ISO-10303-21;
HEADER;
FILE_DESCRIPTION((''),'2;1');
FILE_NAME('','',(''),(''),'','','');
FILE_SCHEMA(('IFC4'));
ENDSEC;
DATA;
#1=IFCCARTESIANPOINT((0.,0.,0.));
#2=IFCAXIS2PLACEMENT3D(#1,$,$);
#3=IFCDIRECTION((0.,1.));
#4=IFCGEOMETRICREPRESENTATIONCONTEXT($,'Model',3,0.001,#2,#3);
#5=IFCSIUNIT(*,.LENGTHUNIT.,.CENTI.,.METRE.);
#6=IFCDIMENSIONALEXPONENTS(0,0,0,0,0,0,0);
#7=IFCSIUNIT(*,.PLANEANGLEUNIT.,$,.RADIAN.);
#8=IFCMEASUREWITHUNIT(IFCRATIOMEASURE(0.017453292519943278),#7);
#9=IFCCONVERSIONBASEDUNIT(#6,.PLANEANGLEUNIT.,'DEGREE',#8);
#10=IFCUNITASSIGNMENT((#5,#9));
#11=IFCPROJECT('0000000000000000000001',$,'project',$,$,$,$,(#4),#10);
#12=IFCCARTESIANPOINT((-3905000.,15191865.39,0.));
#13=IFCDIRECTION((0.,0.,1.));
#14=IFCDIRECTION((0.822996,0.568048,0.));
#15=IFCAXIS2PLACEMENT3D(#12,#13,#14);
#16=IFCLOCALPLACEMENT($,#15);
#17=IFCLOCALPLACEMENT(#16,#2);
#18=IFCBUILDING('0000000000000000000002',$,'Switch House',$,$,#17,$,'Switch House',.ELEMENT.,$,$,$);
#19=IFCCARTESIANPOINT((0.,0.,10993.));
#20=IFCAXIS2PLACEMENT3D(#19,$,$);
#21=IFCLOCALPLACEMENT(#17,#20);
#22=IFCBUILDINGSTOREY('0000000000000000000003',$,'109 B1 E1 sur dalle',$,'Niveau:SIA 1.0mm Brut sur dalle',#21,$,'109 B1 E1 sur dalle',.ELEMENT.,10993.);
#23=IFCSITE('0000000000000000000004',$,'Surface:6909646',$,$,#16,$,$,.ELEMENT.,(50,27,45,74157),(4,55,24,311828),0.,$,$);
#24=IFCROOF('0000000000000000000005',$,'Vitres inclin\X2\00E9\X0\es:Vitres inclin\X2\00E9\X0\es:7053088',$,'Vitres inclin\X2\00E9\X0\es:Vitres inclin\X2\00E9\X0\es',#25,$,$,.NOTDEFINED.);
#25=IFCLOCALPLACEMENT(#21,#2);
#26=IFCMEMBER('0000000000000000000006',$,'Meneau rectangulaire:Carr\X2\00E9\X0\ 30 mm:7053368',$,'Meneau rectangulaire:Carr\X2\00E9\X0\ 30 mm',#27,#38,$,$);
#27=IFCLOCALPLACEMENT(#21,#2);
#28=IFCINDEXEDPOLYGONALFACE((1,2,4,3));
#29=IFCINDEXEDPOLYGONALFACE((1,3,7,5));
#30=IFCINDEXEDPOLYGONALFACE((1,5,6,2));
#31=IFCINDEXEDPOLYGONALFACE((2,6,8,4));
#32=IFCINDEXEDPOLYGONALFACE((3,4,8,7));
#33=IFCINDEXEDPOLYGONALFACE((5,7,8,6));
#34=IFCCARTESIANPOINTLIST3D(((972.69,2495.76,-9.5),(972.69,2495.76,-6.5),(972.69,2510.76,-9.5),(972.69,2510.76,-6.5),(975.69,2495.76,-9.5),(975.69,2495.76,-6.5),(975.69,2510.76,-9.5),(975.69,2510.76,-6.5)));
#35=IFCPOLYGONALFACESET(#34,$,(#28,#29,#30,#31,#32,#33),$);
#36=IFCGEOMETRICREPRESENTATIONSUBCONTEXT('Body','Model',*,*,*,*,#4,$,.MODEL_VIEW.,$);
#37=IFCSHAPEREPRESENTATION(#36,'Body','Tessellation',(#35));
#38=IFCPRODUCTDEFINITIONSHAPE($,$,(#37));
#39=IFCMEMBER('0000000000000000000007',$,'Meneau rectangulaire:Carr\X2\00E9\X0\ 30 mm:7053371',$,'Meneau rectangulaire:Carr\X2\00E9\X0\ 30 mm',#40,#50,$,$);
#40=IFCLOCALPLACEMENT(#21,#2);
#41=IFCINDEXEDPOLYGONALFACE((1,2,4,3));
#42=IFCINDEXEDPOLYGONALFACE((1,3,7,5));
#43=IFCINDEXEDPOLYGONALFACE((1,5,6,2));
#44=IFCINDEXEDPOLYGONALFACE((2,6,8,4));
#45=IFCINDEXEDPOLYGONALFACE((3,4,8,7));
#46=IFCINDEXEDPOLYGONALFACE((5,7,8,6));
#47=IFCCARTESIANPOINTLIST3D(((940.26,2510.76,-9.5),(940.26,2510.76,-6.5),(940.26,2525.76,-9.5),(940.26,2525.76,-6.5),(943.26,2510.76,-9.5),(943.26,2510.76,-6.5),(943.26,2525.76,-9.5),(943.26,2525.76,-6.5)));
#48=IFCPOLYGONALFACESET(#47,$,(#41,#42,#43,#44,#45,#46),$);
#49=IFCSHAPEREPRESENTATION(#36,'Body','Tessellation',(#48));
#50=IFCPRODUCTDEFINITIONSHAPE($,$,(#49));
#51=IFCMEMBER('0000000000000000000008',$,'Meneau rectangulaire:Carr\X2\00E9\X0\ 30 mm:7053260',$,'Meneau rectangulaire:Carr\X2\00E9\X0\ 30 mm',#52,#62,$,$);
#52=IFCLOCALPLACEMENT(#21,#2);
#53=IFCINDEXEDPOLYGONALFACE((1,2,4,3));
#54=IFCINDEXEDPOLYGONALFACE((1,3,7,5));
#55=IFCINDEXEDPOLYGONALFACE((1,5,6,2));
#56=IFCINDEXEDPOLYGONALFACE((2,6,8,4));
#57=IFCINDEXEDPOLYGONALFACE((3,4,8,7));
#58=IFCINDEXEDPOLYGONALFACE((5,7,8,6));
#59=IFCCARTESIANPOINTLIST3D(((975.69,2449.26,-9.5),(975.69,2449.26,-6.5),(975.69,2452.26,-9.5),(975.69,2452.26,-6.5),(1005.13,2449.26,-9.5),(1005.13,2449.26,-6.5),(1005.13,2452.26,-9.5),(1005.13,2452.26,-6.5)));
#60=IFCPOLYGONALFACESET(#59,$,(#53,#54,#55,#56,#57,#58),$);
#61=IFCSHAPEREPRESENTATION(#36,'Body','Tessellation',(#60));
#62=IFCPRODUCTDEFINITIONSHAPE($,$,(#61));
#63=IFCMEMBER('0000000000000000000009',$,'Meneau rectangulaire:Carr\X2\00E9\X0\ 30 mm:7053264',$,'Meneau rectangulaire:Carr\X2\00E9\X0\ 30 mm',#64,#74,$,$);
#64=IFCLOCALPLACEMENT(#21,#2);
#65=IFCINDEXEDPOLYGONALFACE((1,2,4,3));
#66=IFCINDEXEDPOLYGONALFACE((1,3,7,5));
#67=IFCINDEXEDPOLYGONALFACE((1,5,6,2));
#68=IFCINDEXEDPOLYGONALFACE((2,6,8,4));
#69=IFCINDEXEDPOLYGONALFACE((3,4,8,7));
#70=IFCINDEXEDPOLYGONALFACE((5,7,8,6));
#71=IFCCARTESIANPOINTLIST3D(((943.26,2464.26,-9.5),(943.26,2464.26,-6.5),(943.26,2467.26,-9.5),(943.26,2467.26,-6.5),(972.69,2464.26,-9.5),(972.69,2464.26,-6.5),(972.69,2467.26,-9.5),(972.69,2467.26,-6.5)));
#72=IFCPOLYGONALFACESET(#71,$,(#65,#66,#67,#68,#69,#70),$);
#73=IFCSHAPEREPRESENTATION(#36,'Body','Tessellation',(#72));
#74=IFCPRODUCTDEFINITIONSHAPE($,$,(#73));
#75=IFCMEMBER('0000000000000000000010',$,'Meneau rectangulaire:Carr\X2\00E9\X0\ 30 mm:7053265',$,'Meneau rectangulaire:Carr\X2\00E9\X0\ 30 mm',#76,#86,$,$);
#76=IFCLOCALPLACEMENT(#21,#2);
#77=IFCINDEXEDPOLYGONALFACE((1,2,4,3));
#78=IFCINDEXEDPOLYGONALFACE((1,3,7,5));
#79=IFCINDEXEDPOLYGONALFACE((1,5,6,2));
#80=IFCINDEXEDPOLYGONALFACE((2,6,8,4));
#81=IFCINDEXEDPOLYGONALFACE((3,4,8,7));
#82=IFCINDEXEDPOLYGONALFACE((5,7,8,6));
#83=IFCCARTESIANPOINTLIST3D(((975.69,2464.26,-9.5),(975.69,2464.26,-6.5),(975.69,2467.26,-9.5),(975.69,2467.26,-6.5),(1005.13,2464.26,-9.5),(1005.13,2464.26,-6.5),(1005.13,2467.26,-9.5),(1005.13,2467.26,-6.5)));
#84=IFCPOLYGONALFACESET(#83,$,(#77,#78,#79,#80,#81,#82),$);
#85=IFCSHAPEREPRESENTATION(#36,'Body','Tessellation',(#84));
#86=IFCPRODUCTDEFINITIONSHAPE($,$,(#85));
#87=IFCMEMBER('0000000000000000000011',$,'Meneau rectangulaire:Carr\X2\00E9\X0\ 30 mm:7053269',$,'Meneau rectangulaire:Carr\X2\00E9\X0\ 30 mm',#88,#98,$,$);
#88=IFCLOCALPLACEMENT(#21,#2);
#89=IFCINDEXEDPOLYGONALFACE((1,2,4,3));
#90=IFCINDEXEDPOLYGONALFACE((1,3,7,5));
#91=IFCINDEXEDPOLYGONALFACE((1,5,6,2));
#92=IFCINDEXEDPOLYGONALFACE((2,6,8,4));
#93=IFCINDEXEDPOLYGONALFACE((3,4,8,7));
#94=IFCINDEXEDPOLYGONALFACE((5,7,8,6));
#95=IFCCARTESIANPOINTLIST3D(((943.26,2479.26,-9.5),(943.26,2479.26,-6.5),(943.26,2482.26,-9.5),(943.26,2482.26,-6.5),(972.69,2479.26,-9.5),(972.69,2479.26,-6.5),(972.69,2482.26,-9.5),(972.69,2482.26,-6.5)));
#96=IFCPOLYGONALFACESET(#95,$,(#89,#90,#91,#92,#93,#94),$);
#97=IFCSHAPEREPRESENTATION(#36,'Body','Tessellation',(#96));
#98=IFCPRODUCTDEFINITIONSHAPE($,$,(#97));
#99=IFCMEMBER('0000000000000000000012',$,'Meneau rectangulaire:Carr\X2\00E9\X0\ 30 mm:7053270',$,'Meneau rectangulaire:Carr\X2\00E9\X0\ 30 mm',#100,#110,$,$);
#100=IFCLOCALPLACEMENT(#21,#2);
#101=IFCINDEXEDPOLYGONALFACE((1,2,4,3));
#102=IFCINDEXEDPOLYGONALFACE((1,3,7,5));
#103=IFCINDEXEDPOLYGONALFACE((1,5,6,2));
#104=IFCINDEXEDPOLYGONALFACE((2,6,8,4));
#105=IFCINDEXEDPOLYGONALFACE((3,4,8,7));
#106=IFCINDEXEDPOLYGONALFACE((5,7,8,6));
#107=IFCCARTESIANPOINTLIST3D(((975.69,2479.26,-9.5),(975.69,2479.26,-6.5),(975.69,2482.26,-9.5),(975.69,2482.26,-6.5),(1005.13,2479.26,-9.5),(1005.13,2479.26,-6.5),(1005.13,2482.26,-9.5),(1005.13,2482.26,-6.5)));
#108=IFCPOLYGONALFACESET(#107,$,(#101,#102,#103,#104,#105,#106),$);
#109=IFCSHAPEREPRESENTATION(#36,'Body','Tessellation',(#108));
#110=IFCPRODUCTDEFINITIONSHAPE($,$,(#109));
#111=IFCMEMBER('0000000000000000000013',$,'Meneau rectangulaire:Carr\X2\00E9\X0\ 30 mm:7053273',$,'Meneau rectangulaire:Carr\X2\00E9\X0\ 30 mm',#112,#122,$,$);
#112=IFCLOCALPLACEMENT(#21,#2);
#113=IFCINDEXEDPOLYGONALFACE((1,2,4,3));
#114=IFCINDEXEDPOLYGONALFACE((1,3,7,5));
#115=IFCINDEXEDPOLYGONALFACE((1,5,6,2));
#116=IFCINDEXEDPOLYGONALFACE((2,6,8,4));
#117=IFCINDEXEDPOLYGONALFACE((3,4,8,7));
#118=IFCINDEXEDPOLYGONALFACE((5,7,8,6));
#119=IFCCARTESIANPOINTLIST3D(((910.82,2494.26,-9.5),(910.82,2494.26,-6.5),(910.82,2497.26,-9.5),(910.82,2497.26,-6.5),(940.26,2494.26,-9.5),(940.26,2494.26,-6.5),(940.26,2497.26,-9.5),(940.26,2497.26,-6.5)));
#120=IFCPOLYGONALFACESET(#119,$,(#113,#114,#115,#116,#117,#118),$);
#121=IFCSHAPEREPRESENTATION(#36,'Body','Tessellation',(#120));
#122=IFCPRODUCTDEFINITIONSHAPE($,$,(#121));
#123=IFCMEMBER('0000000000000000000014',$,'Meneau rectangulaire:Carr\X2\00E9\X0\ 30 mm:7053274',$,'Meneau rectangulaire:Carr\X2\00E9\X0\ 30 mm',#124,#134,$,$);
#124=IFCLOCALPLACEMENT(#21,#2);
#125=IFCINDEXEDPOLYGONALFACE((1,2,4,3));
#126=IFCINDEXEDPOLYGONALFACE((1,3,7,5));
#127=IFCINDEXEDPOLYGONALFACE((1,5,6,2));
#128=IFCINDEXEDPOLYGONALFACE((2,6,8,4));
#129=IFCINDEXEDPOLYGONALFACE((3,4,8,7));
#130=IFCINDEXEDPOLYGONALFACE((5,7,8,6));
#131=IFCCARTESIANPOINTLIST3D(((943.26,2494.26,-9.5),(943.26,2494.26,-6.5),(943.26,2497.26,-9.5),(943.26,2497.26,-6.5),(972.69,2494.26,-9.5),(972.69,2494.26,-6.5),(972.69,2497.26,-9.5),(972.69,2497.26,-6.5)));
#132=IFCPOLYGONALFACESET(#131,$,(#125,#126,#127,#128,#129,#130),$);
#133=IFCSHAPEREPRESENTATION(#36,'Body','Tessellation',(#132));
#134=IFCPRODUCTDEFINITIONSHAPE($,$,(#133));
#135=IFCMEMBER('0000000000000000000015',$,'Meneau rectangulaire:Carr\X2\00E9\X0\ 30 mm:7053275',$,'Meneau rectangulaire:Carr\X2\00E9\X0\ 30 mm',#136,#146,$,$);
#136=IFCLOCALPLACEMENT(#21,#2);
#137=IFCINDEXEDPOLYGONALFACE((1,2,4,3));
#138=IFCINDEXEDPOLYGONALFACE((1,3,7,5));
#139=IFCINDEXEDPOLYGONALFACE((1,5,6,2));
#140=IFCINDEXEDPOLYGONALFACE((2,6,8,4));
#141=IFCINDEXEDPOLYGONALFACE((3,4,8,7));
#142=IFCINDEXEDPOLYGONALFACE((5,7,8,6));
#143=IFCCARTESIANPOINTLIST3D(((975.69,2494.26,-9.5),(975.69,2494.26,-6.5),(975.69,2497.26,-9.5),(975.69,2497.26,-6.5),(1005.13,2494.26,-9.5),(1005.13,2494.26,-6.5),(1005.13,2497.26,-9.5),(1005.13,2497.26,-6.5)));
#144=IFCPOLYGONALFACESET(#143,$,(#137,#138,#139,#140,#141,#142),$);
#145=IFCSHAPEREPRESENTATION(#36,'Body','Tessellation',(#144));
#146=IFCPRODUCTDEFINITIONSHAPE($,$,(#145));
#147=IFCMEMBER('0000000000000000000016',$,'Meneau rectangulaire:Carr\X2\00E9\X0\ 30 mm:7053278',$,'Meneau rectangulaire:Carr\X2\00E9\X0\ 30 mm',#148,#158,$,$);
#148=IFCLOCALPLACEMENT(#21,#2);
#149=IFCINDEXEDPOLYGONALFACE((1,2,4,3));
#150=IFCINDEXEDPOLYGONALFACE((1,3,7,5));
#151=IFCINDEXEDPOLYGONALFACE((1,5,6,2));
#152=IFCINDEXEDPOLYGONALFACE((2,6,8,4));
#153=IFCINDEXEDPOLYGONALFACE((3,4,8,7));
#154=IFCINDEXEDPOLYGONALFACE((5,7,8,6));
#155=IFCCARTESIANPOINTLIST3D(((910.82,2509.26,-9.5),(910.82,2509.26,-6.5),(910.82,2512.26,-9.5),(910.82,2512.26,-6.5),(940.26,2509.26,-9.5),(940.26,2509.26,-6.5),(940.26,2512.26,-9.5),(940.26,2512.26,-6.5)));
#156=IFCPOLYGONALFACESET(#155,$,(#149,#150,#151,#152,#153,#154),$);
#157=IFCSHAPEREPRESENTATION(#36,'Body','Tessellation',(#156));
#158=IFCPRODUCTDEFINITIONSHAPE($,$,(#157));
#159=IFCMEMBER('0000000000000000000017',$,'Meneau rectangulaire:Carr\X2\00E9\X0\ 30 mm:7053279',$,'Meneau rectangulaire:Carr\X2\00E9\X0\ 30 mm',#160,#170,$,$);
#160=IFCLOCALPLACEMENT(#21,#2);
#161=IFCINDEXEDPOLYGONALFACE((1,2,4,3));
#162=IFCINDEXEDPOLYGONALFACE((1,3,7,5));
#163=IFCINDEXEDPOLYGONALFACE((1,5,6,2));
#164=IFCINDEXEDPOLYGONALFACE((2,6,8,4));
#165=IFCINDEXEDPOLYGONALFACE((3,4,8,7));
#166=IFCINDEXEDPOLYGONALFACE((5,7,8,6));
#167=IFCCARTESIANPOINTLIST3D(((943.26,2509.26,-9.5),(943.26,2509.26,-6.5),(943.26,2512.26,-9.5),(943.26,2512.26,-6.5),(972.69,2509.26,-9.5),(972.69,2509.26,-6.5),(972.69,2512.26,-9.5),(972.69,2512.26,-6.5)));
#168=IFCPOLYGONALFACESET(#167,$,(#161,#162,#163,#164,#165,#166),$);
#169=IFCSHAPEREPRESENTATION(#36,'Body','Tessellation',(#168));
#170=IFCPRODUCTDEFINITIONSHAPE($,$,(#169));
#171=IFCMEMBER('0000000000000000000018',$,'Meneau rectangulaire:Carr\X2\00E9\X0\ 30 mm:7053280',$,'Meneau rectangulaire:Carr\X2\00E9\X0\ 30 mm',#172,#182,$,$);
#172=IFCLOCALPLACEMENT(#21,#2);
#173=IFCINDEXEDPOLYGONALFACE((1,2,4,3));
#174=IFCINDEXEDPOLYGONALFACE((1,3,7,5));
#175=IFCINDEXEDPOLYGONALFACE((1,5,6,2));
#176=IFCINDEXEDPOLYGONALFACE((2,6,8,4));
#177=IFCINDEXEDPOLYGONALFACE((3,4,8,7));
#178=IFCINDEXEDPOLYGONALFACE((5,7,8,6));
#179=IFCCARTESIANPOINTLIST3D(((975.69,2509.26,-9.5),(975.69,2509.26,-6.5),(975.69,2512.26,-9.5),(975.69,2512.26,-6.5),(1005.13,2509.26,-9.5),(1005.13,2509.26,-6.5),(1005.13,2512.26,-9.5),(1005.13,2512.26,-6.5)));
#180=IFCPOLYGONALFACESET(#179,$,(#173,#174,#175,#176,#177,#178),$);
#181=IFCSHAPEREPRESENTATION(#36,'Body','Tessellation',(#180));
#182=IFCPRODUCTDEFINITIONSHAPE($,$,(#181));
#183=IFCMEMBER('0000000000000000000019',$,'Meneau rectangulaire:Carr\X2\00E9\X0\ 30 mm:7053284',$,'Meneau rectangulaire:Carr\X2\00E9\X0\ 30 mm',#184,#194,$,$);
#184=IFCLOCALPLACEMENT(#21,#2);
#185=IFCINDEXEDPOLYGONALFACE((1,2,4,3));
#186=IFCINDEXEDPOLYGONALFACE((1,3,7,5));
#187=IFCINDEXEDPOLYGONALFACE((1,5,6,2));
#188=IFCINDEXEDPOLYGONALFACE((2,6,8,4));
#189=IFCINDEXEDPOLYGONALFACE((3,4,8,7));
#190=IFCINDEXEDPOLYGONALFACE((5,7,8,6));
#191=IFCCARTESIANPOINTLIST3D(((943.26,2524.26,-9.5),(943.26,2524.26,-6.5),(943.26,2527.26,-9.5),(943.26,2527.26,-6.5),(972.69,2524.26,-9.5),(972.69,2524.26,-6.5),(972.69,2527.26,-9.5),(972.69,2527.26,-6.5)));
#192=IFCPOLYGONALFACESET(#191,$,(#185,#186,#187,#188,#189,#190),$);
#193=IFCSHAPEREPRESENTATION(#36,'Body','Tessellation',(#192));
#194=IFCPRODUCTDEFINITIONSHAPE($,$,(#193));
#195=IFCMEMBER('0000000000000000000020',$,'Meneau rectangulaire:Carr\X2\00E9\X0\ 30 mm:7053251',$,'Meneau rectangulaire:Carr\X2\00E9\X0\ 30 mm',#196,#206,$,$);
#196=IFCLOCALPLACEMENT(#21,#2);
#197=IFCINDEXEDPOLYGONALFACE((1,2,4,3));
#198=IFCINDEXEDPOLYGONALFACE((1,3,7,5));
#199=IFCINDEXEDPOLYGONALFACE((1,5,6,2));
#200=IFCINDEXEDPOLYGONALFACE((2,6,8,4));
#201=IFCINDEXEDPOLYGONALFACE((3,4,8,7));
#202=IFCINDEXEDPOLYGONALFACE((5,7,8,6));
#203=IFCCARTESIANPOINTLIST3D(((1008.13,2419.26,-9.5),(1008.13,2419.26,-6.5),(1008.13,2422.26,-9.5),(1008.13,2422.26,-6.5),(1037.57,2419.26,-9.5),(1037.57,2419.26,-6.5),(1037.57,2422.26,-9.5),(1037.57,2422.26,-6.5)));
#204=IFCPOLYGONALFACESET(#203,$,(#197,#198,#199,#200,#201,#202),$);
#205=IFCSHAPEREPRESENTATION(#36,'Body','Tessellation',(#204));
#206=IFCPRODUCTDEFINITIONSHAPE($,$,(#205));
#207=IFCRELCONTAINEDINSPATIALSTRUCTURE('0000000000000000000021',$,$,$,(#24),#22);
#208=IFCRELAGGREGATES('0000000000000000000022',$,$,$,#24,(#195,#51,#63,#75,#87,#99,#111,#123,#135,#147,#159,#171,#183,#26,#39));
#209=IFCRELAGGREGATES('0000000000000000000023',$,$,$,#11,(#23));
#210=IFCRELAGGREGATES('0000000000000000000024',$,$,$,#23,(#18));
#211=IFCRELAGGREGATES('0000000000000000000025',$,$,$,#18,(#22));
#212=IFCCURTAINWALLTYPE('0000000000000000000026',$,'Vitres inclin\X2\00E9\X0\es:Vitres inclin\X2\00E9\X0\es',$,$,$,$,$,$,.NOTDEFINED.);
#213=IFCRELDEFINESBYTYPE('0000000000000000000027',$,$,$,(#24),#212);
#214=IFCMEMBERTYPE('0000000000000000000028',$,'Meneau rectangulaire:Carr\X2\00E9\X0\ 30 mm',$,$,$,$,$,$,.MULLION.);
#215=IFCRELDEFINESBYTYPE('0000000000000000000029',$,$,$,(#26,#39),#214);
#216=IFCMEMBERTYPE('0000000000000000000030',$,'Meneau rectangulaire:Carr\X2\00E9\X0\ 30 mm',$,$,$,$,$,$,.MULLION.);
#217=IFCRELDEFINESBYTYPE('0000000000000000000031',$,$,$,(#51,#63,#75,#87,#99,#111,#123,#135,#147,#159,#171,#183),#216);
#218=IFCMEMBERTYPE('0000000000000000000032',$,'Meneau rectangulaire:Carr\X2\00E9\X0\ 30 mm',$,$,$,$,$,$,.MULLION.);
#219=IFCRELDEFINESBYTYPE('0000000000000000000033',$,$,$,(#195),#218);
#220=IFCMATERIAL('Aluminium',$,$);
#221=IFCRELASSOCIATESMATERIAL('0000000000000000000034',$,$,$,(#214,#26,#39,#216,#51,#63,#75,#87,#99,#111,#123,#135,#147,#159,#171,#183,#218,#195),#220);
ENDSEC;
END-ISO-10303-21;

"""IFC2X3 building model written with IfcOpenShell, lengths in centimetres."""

from ifc_helpers import new_model, entity, si_unit, converted_unit, direction, frame, origin, origin_2d_with_axis, place, context, subcontext, project, spatial, rectangle, extrude, source, transform, mapped, material, type_object, type_shapes, element, aggregate, save


model = new_model("IFC2X3")

# Units and contexts
model_context = context("Model", 3, precision=0.001, world=origin(), true_north=direction((0.0, 1.0)))
body_context = subcontext(model_context, "Body", "Model", "MODEL_VIEW")
ifc_project = project(units=[si_unit("LENGTHUNIT", "METRE", prefix="CENTI"), converted_unit("PLANEANGLEUNIT", "DEGREE", entity("IfcRatioMeasure", 0.017453292519943278), si_unit("PLANEANGLEUNIT", "RADIAN"), dimensions=[0, 0, 0, 0, 0, 0, 0])], contexts=[model_context])

# Site, building, storey
site_placement = place(None, frame((-3905000.0, 15191865.39, 0.0), z_axis=(0.0, 0.0, 1.0), x_axis=(0.822996, 0.568048, 0.0)))
site = spatial("IfcSite", under=ifc_project, at=site_placement, Name="Surface:6909646", CompositionType="ELEMENT", RefLatitude=(50, 27, 45, 74157), RefLongitude=(4, 55, 24, 311828), RefElevation=0.0)
building_placement = place(site_placement, origin())
building = spatial("IfcBuilding", under=site, at=building_placement, Name="Switch House", LongName="Switch House", CompositionType="ELEMENT")
storey_placement = place(building_placement, frame((0.0, 0.0, 10993.0)))
storey = spatial("IfcBuildingStorey", under=building, at=storey_placement, Name="109 B1 E1 sur dalle", ObjectType="Niveau:SIA 1.0mm Brut sur dalle", LongName="109 B1 E1 sur dalle", CompositionType="ELEMENT", Elevation=10993.0)

# Roof, members
curtain_wall_type = type_object("IfcCurtainWallType", Name="Vitres inclinées:Vitres inclinées", PredefinedType="NOTDEFINED")
roof_placement = place(storey_placement, frame((0.0, 0.0, -10993.0)))
roof = element("IfcRoof", 1, at=roof_placement, inside=storey, type_object=curtain_wall_type, Name="Vitres inclinées:Vitres inclinées:7053088", ObjectType="Vitres inclinées:Vitres inclinées", ShapeType="NOTDEFINED")
ifc_material = material(Name="Aluminium")
member_type_1 = type_object("IfcMemberType", Name="Meneau rectangulaire:Carré 30 mm", PredefinedType="MULLION", material=ifc_material)
shared_shape_1 = source(origin(), body_context, "Body", "SweptSolid", [
    extrude(rectangle(XDim=3.0, YDim=3.0, at=origin_2d_with_axis()), frame((0.0, 0.0, -15.0), z_axis=(0.0, 0.0, 1.0), x_axis=(0.0, -1.0, 0.0)), (0.0, 0.0, 1.0), 15.0),
])
type_shapes(member_type_1, [shared_shape_1])
member_1_placement = place(roof_placement, frame((974.19, 2510.76, 10985.0), z_axis=(0.0, 1.0, 0.0), x_axis=(1.0, 0.0, 0.0)))
member_1 = element("IfcMember", 2, at=member_1_placement, type_object=member_type_1, material=ifc_material, Name="Meneau rectangulaire:Carré 30 mm:7053368", ObjectType="Meneau rectangulaire:Carré 30 mm", context=body_context, shape_type="MappedRepresentation", body=[
    mapped(shared_shape_1, transform((0.0, 0.0, 0.0), scale=1.0)),
])
member_2_placement = place(roof_placement, frame((941.76, 2525.76, 10985.0), z_axis=(0.0, 1.0, 0.0), x_axis=(1.0, 0.0, 0.0)))
member_2 = element("IfcMember", 3, at=member_2_placement, type_object=member_type_1, material=ifc_material, Name="Meneau rectangulaire:Carré 30 mm:7053371", ObjectType="Meneau rectangulaire:Carré 30 mm", context=body_context, shape_type="MappedRepresentation", body=[
    mapped(shared_shape_1, transform((0.0, 0.0, 0.0), scale=1.0)),
])
member_type_2 = type_object("IfcMemberType", Name="Meneau rectangulaire:Carré 30 mm", PredefinedType="MULLION", material=ifc_material)
shared_shape_2 = source(origin(), body_context, "Body", "SweptSolid", [
    extrude(rectangle(XDim=3.0, YDim=3.0, at=origin_2d_with_axis()), frame((0.0, 0.0, -29.44), z_axis=(0.0, 0.0, 1.0), x_axis=(0.0, -1.0, 0.0)), (0.0, 0.0, 1.0), 29.44),
])
type_shapes(member_type_2, [shared_shape_2])
member_3_placement = place(roof_placement, frame((975.69, 2450.76, 10985.0), z_axis=(-1.0, 0.0, 0.0), x_axis=(0.0, 1.0, 0.0)))
member_3 = element("IfcMember", 4, at=member_3_placement, type_object=member_type_2, material=ifc_material, Name="Meneau rectangulaire:Carré 30 mm:7053260", ObjectType="Meneau rectangulaire:Carré 30 mm", context=body_context, shape_type="MappedRepresentation", body=[
    mapped(shared_shape_2, transform((0.0, 0.0, 0.0), scale=1.0)),
])
member_4_placement = place(roof_placement, frame((943.26, 2465.76, 10985.0), z_axis=(-1.0, 0.0, 0.0), x_axis=(0.0, 1.0, 0.0)))
member_4 = element("IfcMember", 5, at=member_4_placement, type_object=member_type_2, material=ifc_material, Name="Meneau rectangulaire:Carré 30 mm:7053264", ObjectType="Meneau rectangulaire:Carré 30 mm", context=body_context, shape_type="MappedRepresentation", body=[
    mapped(shared_shape_2, transform((0.0, 0.0, 0.0), scale=1.0)),
])
member_5_placement = place(roof_placement, frame((975.69, 2465.76, 10985.0), z_axis=(-1.0, 0.0, 0.0), x_axis=(0.0, 1.0, 0.0)))
member_5 = element("IfcMember", 6, at=member_5_placement, type_object=member_type_2, material=ifc_material, Name="Meneau rectangulaire:Carré 30 mm:7053265", ObjectType="Meneau rectangulaire:Carré 30 mm", context=body_context, shape_type="MappedRepresentation", body=[
    mapped(shared_shape_2, transform((0.0, 0.0, 0.0), scale=1.0)),
])
member_6_placement = place(roof_placement, frame((943.26, 2480.76, 10985.0), z_axis=(-1.0, 0.0, 0.0), x_axis=(0.0, 1.0, 0.0)))
member_6 = element("IfcMember", 7, at=member_6_placement, type_object=member_type_2, material=ifc_material, Name="Meneau rectangulaire:Carré 30 mm:7053269", ObjectType="Meneau rectangulaire:Carré 30 mm", context=body_context, shape_type="MappedRepresentation", body=[
    mapped(shared_shape_2, transform((0.0, 0.0, 0.0), scale=1.0)),
])
member_7_placement = place(roof_placement, frame((975.69, 2480.76, 10985.0), z_axis=(-1.0, 0.0, 0.0), x_axis=(0.0, 1.0, 0.0)))
member_7 = element("IfcMember", 8, at=member_7_placement, type_object=member_type_2, material=ifc_material, Name="Meneau rectangulaire:Carré 30 mm:7053270", ObjectType="Meneau rectangulaire:Carré 30 mm", context=body_context, shape_type="MappedRepresentation", body=[
    mapped(shared_shape_2, transform((0.0, 0.0, 0.0), scale=1.0)),
])
member_8_placement = place(roof_placement, frame((910.82, 2495.76, 10985.0), z_axis=(-1.0, 0.0, 0.0), x_axis=(0.0, 1.0, 0.0)))
member_8 = element("IfcMember", 9, at=member_8_placement, type_object=member_type_2, material=ifc_material, Name="Meneau rectangulaire:Carré 30 mm:7053273", ObjectType="Meneau rectangulaire:Carré 30 mm", context=body_context, shape_type="MappedRepresentation", body=[
    mapped(shared_shape_2, transform((0.0, 0.0, 0.0), scale=1.0)),
])
member_9_placement = place(roof_placement, frame((943.26, 2495.76, 10985.0), z_axis=(-1.0, 0.0, 0.0), x_axis=(0.0, 1.0, 0.0)))
member_9 = element("IfcMember", 10, at=member_9_placement, type_object=member_type_2, material=ifc_material, Name="Meneau rectangulaire:Carré 30 mm:7053274", ObjectType="Meneau rectangulaire:Carré 30 mm", context=body_context, shape_type="MappedRepresentation", body=[
    mapped(shared_shape_2, transform((0.0, 0.0, 0.0), scale=1.0)),
])
member_10_placement = place(roof_placement, frame((975.69, 2495.76, 10985.0), z_axis=(-1.0, 0.0, 0.0), x_axis=(0.0, 1.0, 0.0)))
member_10 = element("IfcMember", 11, at=member_10_placement, type_object=member_type_2, material=ifc_material, Name="Meneau rectangulaire:Carré 30 mm:7053275", ObjectType="Meneau rectangulaire:Carré 30 mm", context=body_context, shape_type="MappedRepresentation", body=[
    mapped(shared_shape_2, transform((0.0, 0.0, 0.0), scale=1.0)),
])
member_11_placement = place(roof_placement, frame((910.82, 2510.76, 10985.0), z_axis=(-1.0, 0.0, 0.0), x_axis=(0.0, 1.0, 0.0)))
member_11 = element("IfcMember", 12, at=member_11_placement, type_object=member_type_2, material=ifc_material, Name="Meneau rectangulaire:Carré 30 mm:7053278", ObjectType="Meneau rectangulaire:Carré 30 mm", context=body_context, shape_type="MappedRepresentation", body=[
    mapped(shared_shape_2, transform((0.0, 0.0, 0.0), scale=1.0)),
])
member_12_placement = place(roof_placement, frame((943.26, 2510.76, 10985.0), z_axis=(-1.0, 0.0, 0.0), x_axis=(0.0, 1.0, 0.0)))
member_12 = element("IfcMember", 13, at=member_12_placement, type_object=member_type_2, material=ifc_material, Name="Meneau rectangulaire:Carré 30 mm:7053279", ObjectType="Meneau rectangulaire:Carré 30 mm", context=body_context, shape_type="MappedRepresentation", body=[
    mapped(shared_shape_2, transform((0.0, 0.0, 0.0), scale=1.0)),
])
member_13_placement = place(roof_placement, frame((975.69, 2510.76, 10985.0), z_axis=(-1.0, 0.0, 0.0), x_axis=(0.0, 1.0, 0.0)))
member_13 = element("IfcMember", 14, at=member_13_placement, type_object=member_type_2, material=ifc_material, Name="Meneau rectangulaire:Carré 30 mm:7053280", ObjectType="Meneau rectangulaire:Carré 30 mm", context=body_context, shape_type="MappedRepresentation", body=[
    mapped(shared_shape_2, transform((0.0, 0.0, 0.0), scale=1.0)),
])
member_14_placement = place(roof_placement, frame((943.26, 2525.76, 10985.0), z_axis=(-1.0, 0.0, 0.0), x_axis=(0.0, 1.0, 0.0)))
member_14 = element("IfcMember", 15, at=member_14_placement, type_object=member_type_2, material=ifc_material, Name="Meneau rectangulaire:Carré 30 mm:7053284", ObjectType="Meneau rectangulaire:Carré 30 mm", context=body_context, shape_type="MappedRepresentation", body=[
    mapped(shared_shape_2, transform((0.0, 0.0, 0.0), scale=1.0)),
])
member_type_3 = type_object("IfcMemberType", Name="Meneau rectangulaire:Carré 30 mm", PredefinedType="MULLION", material=ifc_material)
shared_shape_3 = source(origin(), body_context, "Body", "SweptSolid", [
    extrude(rectangle(XDim=3.0, YDim=3.0, at=origin_2d_with_axis()), frame((0.0, 0.0, -29.44), z_axis=(0.0, 0.0, 1.0), x_axis=(0.0, -1.0, 0.0)), (0.0, 0.0, 1.0), 29.44),
])
type_shapes(member_type_3, [shared_shape_3])
member_15_placement = place(roof_placement, frame((1008.13, 2420.76, 10985.0), z_axis=(-1.0, 0.0, 0.0), x_axis=(0.0, 1.0, 0.0)))
member_15 = element("IfcMember", 16, at=member_15_placement, type_object=member_type_3, material=ifc_material, Name="Meneau rectangulaire:Carré 30 mm:7053251", ObjectType="Meneau rectangulaire:Carré 30 mm", context=body_context, shape_type="MappedRepresentation", body=[
    mapped(shared_shape_3, transform((0.0, 0.0, 0.0), scale=1.0)),
])
aggregate(roof, [member_15, member_3, member_4, member_5, member_6, member_7, member_8, member_9, member_10, member_11, member_12, member_13, member_14, member_1, member_2])

save(model, "model.ifc")
